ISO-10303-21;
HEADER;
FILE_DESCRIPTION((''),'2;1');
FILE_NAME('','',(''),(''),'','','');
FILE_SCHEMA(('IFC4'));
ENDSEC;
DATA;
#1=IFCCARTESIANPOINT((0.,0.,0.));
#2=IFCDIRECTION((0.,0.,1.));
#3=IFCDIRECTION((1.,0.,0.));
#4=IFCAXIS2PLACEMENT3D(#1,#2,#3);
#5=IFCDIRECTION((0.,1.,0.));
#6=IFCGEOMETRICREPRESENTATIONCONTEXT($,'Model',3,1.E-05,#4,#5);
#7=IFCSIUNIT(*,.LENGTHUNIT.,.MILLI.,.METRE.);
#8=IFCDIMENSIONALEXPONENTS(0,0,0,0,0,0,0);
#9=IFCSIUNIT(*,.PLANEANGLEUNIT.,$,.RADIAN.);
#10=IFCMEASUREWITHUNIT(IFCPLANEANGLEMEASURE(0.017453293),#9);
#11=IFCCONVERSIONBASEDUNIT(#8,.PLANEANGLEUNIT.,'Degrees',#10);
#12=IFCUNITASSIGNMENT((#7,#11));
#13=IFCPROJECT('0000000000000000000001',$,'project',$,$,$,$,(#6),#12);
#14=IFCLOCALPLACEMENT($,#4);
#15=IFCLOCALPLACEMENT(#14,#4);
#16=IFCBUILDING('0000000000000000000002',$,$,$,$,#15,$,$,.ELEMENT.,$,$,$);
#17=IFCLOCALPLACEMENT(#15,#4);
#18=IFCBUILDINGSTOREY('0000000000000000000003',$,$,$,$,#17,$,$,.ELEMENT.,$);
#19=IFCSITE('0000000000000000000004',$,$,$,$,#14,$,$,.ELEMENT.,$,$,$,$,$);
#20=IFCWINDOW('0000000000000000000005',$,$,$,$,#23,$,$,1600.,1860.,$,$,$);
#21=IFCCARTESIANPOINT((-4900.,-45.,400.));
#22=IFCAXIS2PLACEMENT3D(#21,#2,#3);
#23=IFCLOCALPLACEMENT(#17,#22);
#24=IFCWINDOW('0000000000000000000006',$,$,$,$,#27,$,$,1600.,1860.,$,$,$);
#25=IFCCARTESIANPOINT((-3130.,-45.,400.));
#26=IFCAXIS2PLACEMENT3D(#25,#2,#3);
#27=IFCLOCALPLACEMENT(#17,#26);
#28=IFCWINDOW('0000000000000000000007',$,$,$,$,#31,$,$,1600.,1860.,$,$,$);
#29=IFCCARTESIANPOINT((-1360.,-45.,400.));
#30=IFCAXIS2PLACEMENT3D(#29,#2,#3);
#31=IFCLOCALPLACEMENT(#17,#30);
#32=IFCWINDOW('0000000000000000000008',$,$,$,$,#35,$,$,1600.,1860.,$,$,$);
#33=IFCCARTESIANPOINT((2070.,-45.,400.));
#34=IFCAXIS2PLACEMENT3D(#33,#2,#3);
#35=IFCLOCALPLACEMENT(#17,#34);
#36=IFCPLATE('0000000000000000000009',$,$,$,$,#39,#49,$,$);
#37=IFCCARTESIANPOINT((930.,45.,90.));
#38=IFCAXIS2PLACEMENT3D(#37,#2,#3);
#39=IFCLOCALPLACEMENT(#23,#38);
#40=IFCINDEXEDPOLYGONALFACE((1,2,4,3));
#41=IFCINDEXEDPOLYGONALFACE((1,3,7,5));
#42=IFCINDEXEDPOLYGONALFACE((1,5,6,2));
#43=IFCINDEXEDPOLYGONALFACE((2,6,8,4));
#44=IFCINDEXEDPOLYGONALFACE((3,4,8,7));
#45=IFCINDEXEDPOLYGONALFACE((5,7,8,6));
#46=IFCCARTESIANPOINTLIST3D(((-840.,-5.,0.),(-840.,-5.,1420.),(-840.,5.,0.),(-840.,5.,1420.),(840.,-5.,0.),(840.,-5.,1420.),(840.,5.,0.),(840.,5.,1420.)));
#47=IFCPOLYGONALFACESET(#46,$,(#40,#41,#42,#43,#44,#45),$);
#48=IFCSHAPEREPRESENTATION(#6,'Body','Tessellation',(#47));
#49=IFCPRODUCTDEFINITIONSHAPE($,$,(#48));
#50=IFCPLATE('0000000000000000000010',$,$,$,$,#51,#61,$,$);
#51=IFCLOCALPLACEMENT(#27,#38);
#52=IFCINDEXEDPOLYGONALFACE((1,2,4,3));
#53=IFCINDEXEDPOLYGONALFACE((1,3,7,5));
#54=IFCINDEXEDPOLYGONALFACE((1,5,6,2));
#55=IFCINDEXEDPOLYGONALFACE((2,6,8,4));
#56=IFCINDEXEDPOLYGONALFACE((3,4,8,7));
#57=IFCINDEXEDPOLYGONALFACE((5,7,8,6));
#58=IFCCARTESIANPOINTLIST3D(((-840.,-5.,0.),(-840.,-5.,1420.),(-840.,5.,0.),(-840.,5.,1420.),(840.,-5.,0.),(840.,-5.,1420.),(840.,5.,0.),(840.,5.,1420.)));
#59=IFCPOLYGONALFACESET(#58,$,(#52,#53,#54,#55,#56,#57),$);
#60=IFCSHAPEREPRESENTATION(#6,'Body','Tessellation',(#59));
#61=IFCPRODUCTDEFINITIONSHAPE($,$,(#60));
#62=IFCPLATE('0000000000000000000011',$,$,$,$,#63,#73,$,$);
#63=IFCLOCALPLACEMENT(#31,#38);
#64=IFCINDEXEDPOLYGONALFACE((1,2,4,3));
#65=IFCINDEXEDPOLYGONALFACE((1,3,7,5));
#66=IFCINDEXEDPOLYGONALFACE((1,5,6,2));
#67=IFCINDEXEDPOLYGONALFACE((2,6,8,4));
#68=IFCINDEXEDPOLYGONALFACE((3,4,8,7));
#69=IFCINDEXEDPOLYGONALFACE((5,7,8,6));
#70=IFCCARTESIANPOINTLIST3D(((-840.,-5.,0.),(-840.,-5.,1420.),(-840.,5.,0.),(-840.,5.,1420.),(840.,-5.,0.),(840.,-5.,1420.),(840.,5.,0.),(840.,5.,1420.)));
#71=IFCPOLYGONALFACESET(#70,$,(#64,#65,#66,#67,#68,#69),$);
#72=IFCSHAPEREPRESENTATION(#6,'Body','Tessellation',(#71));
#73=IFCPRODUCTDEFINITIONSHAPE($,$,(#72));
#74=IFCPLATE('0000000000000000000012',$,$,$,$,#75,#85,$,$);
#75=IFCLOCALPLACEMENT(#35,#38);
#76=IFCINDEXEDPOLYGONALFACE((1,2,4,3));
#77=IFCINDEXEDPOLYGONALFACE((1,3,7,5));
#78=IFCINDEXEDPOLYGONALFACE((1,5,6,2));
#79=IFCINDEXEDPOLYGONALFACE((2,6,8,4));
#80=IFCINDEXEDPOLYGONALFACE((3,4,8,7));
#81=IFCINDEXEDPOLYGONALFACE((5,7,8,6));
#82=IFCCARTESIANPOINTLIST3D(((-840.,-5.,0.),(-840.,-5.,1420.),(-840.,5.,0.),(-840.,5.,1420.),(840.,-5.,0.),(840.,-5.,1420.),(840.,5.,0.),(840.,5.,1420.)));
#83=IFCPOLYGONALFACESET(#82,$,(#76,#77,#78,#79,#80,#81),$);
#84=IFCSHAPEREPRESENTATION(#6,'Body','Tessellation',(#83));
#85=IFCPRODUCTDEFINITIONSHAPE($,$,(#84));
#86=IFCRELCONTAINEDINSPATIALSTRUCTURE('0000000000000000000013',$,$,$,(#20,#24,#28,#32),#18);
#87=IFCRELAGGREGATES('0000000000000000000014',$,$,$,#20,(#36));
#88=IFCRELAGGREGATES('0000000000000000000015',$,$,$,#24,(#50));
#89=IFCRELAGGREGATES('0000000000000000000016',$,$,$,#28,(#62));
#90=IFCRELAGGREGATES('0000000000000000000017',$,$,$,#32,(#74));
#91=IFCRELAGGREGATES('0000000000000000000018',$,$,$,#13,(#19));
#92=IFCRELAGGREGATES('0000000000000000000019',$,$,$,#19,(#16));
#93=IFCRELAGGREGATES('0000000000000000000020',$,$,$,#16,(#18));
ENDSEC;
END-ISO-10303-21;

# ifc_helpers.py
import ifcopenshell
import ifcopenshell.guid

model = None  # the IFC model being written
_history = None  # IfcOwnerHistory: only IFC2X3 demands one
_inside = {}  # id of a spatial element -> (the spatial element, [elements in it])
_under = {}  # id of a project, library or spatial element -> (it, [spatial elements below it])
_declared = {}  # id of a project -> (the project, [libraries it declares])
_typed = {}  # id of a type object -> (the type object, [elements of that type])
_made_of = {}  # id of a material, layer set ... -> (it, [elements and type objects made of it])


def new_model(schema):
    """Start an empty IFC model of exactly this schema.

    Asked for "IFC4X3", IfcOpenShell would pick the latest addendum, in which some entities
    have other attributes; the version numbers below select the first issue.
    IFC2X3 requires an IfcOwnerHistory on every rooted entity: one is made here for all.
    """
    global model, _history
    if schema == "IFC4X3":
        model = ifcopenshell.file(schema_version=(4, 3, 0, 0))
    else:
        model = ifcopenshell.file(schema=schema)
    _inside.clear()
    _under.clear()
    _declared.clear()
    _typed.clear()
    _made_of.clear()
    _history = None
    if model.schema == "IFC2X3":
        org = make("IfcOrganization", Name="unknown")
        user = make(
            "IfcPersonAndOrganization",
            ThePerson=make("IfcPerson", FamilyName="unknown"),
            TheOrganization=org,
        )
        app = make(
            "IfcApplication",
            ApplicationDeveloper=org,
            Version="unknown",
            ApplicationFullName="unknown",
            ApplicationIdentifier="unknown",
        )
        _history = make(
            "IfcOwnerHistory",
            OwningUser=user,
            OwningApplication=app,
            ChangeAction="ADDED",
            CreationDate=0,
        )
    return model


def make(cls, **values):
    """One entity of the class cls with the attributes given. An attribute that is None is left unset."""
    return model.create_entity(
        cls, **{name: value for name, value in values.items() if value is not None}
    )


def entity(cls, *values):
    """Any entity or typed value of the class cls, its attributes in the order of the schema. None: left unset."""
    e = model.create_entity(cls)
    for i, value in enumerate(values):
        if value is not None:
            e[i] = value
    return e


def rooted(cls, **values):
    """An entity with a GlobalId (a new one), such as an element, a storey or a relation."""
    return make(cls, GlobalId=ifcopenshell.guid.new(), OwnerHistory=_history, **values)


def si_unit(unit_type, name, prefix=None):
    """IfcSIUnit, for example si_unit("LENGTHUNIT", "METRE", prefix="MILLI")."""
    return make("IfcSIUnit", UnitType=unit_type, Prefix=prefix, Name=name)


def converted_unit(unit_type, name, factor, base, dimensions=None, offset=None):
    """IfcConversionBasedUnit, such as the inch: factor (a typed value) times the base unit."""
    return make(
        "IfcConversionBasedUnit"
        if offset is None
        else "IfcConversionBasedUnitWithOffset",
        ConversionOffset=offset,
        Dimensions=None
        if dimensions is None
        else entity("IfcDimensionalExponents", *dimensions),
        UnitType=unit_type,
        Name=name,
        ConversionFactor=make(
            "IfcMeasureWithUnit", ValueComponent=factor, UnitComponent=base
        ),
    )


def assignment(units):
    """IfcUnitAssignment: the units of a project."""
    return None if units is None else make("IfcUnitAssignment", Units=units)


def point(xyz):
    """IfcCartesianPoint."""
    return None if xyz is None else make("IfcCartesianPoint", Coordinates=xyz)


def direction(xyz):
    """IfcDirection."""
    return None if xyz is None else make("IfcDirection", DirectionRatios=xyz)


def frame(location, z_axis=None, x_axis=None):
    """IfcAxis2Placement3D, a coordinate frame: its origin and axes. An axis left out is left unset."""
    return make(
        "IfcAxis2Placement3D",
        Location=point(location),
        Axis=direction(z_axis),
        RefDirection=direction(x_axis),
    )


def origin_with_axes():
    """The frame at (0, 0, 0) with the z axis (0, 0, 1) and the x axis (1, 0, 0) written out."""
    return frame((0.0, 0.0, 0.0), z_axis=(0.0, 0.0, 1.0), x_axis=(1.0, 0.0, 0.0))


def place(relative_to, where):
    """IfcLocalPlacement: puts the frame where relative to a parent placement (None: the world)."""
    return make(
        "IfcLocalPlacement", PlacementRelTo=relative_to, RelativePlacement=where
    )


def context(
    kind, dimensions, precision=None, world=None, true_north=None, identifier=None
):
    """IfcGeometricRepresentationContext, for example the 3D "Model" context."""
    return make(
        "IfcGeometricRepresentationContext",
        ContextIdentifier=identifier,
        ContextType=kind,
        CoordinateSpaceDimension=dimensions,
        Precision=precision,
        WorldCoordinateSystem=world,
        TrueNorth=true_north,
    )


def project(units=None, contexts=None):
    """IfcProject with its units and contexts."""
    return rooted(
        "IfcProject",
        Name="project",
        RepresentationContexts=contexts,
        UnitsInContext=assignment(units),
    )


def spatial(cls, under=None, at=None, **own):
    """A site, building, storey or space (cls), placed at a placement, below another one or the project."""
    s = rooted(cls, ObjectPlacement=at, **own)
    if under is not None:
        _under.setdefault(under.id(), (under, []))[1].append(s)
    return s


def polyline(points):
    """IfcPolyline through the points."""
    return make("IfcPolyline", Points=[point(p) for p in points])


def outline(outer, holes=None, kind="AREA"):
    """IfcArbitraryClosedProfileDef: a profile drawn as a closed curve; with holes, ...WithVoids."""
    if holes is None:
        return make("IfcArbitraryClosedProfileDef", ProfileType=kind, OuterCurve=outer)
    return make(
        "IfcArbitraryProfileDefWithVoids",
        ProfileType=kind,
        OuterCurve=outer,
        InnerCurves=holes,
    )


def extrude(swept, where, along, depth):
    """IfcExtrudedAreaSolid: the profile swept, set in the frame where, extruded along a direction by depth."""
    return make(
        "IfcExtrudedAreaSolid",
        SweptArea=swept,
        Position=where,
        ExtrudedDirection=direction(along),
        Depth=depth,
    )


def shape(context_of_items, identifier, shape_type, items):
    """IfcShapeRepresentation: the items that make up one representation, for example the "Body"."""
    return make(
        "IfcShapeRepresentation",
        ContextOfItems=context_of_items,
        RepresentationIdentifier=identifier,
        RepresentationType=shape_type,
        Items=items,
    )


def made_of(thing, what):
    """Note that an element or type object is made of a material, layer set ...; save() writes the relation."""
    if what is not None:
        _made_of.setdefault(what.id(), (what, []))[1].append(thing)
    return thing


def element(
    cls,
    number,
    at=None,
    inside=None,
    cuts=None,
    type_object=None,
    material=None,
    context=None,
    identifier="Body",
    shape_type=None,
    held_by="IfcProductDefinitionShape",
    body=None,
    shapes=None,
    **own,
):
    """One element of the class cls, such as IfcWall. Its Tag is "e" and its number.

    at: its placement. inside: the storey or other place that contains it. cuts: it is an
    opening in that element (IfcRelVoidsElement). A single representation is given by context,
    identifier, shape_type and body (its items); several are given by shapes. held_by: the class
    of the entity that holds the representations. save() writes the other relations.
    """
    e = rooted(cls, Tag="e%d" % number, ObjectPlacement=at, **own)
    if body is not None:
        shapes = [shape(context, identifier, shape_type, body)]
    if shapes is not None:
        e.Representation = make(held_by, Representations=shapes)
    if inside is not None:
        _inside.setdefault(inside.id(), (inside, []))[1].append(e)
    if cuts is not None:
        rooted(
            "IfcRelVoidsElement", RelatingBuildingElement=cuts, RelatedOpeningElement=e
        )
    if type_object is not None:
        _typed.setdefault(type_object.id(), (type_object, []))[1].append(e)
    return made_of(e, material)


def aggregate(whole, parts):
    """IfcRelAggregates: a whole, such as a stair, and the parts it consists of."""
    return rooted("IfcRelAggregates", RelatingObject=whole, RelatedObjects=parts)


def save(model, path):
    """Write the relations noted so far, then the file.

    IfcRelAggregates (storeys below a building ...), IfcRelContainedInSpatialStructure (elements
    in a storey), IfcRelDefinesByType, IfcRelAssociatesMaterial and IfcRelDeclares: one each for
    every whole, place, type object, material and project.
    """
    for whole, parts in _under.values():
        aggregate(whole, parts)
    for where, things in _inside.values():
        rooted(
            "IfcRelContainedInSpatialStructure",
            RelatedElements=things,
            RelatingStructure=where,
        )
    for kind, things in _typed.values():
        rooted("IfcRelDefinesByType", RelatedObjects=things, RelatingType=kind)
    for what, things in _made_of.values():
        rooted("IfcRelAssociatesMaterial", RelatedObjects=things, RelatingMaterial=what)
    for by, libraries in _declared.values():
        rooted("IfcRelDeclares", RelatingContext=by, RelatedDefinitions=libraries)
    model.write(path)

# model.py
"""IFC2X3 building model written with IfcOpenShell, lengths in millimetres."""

from ifc_helpers import new_model, entity, si_unit, converted_unit, direction, frame, origin_with_axes, place, context, project, spatial, polyline, outline, extrude, element, aggregate, save


model = new_model("IFC2X3")

# Units and contexts
model_context = context("Model", 3, precision=1e-05, world=origin_with_axes(), true_north=direction((0.0, 1.0, 0.0)))
ifc_project = project(units=[si_unit("LENGTHUNIT", "METRE", prefix="MILLI"), converted_unit("PLANEANGLEUNIT", "Degrees", entity("IfcPlaneAngleMeasure", 0.017453293), si_unit("PLANEANGLEUNIT", "RADIAN"), dimensions=[0, 0, 0, 0, 0, 0, 0])], contexts=[model_context])

# Site, building, storey
site_placement = place(None, origin_with_axes())
site = spatial("IfcSite", under=ifc_project, at=site_placement, CompositionType="ELEMENT")
building_placement = place(site_placement, origin_with_axes())
building = spatial("IfcBuilding", under=site, at=building_placement, CompositionType="ELEMENT")
storey_placement = place(building_placement, origin_with_axes())
storey = spatial("IfcBuildingStorey", under=building, at=storey_placement, CompositionType="ELEMENT")

# Windows
window_1_placement = place(storey_placement, frame((-4900.0, -45.0, 400.0), z_axis=(0.0, 0.0, 1.0), x_axis=(1.0, 0.0, 0.0)))
window_1 = element("IfcWindow", 1, at=window_1_placement, inside=storey, OverallHeight=1600.0, OverallWidth=1860.0)
window_2_placement = place(storey_placement, frame((-3130.0, -45.0, 400.0), z_axis=(0.0, 0.0, 1.0), x_axis=(1.0, 0.0, 0.0)))
window_2 = element("IfcWindow", 2, at=window_2_placement, inside=storey, OverallHeight=1600.0, OverallWidth=1860.0)
window_3_placement = place(storey_placement, frame((-1360.0, -45.0, 400.0), z_axis=(0.0, 0.0, 1.0), x_axis=(1.0, 0.0, 0.0)))
window_3 = element("IfcWindow", 3, at=window_3_placement, inside=storey, OverallHeight=1600.0, OverallWidth=1860.0)
window_4_placement = place(storey_placement, frame((2070.0, -45.0, 400.0), z_axis=(0.0, 0.0, 1.0), x_axis=(1.0, 0.0, 0.0)))
window_4 = element("IfcWindow", 4, at=window_4_placement, inside=storey, OverallHeight=1600.0, OverallWidth=1860.0)

# Plates
plate_1_placement = place(window_1_placement, frame((930.0, 45.0, 90.0), z_axis=(0.0, 0.0, 1.0), x_axis=(1.0, 0.0, 0.0)))
plate_1 = element("IfcPlate", 5, at=plate_1_placement, context=model_context, shape_type="SweptSolid", body=[
    extrude(outline(polyline([(-840.0, -5.0), (840.0, -5.0), (840.0, 5.0), (-840.0, 5.0), (-840.0, -5.0)])), origin_with_axes(), (0.0, 0.0, 1.0), 1420.0),
])
aggregate(window_1, [plate_1])
plate_2_placement = place(window_2_placement, frame((930.0, 45.0, 90.0), z_axis=(0.0, 0.0, 1.0), x_axis=(1.0, 0.0, 0.0)))
plate_2 = element("IfcPlate", 6, at=plate_2_placement, context=model_context, shape_type="SweptSolid", body=[
    extrude(outline(polyline([(-840.0, -5.0), (840.0, -5.0), (840.0, 5.0), (-840.0, 5.0), (-840.0, -5.0)])), origin_with_axes(), (0.0, 0.0, 1.0), 1420.0),
])
aggregate(window_2, [plate_2])
plate_3_placement = place(window_3_placement, frame((930.0, 45.0, 90.0), z_axis=(0.0, 0.0, 1.0), x_axis=(1.0, 0.0, 0.0)))
plate_3 = element("IfcPlate", 7, at=plate_3_placement, context=model_context, shape_type="SweptSolid", body=[
    extrude(outline(polyline([(-840.0, -5.0), (840.0, -5.0), (840.0, 5.0), (-840.0, 5.0), (-840.0, -5.0)])), origin_with_axes(), (0.0, 0.0, 1.0), 1420.0),
])
aggregate(window_3, [plate_3])
plate_4_placement = place(window_4_placement, frame((930.0, 45.0, 90.0), z_axis=(0.0, 0.0, 1.0), x_axis=(1.0, 0.0, 0.0)))
plate_4 = element("IfcPlate", 8, at=plate_4_placement, context=model_context, shape_type="SweptSolid", body=[
    extrude(outline(polyline([(-840.0, -5.0), (840.0, -5.0), (840.0, 5.0), (-840.0, 5.0), (-840.0, -5.0)])), origin_with_axes(), (0.0, 0.0, 1.0), 1420.0),
])
aggregate(window_4, [plate_4])

save(model, "model.ifc")
